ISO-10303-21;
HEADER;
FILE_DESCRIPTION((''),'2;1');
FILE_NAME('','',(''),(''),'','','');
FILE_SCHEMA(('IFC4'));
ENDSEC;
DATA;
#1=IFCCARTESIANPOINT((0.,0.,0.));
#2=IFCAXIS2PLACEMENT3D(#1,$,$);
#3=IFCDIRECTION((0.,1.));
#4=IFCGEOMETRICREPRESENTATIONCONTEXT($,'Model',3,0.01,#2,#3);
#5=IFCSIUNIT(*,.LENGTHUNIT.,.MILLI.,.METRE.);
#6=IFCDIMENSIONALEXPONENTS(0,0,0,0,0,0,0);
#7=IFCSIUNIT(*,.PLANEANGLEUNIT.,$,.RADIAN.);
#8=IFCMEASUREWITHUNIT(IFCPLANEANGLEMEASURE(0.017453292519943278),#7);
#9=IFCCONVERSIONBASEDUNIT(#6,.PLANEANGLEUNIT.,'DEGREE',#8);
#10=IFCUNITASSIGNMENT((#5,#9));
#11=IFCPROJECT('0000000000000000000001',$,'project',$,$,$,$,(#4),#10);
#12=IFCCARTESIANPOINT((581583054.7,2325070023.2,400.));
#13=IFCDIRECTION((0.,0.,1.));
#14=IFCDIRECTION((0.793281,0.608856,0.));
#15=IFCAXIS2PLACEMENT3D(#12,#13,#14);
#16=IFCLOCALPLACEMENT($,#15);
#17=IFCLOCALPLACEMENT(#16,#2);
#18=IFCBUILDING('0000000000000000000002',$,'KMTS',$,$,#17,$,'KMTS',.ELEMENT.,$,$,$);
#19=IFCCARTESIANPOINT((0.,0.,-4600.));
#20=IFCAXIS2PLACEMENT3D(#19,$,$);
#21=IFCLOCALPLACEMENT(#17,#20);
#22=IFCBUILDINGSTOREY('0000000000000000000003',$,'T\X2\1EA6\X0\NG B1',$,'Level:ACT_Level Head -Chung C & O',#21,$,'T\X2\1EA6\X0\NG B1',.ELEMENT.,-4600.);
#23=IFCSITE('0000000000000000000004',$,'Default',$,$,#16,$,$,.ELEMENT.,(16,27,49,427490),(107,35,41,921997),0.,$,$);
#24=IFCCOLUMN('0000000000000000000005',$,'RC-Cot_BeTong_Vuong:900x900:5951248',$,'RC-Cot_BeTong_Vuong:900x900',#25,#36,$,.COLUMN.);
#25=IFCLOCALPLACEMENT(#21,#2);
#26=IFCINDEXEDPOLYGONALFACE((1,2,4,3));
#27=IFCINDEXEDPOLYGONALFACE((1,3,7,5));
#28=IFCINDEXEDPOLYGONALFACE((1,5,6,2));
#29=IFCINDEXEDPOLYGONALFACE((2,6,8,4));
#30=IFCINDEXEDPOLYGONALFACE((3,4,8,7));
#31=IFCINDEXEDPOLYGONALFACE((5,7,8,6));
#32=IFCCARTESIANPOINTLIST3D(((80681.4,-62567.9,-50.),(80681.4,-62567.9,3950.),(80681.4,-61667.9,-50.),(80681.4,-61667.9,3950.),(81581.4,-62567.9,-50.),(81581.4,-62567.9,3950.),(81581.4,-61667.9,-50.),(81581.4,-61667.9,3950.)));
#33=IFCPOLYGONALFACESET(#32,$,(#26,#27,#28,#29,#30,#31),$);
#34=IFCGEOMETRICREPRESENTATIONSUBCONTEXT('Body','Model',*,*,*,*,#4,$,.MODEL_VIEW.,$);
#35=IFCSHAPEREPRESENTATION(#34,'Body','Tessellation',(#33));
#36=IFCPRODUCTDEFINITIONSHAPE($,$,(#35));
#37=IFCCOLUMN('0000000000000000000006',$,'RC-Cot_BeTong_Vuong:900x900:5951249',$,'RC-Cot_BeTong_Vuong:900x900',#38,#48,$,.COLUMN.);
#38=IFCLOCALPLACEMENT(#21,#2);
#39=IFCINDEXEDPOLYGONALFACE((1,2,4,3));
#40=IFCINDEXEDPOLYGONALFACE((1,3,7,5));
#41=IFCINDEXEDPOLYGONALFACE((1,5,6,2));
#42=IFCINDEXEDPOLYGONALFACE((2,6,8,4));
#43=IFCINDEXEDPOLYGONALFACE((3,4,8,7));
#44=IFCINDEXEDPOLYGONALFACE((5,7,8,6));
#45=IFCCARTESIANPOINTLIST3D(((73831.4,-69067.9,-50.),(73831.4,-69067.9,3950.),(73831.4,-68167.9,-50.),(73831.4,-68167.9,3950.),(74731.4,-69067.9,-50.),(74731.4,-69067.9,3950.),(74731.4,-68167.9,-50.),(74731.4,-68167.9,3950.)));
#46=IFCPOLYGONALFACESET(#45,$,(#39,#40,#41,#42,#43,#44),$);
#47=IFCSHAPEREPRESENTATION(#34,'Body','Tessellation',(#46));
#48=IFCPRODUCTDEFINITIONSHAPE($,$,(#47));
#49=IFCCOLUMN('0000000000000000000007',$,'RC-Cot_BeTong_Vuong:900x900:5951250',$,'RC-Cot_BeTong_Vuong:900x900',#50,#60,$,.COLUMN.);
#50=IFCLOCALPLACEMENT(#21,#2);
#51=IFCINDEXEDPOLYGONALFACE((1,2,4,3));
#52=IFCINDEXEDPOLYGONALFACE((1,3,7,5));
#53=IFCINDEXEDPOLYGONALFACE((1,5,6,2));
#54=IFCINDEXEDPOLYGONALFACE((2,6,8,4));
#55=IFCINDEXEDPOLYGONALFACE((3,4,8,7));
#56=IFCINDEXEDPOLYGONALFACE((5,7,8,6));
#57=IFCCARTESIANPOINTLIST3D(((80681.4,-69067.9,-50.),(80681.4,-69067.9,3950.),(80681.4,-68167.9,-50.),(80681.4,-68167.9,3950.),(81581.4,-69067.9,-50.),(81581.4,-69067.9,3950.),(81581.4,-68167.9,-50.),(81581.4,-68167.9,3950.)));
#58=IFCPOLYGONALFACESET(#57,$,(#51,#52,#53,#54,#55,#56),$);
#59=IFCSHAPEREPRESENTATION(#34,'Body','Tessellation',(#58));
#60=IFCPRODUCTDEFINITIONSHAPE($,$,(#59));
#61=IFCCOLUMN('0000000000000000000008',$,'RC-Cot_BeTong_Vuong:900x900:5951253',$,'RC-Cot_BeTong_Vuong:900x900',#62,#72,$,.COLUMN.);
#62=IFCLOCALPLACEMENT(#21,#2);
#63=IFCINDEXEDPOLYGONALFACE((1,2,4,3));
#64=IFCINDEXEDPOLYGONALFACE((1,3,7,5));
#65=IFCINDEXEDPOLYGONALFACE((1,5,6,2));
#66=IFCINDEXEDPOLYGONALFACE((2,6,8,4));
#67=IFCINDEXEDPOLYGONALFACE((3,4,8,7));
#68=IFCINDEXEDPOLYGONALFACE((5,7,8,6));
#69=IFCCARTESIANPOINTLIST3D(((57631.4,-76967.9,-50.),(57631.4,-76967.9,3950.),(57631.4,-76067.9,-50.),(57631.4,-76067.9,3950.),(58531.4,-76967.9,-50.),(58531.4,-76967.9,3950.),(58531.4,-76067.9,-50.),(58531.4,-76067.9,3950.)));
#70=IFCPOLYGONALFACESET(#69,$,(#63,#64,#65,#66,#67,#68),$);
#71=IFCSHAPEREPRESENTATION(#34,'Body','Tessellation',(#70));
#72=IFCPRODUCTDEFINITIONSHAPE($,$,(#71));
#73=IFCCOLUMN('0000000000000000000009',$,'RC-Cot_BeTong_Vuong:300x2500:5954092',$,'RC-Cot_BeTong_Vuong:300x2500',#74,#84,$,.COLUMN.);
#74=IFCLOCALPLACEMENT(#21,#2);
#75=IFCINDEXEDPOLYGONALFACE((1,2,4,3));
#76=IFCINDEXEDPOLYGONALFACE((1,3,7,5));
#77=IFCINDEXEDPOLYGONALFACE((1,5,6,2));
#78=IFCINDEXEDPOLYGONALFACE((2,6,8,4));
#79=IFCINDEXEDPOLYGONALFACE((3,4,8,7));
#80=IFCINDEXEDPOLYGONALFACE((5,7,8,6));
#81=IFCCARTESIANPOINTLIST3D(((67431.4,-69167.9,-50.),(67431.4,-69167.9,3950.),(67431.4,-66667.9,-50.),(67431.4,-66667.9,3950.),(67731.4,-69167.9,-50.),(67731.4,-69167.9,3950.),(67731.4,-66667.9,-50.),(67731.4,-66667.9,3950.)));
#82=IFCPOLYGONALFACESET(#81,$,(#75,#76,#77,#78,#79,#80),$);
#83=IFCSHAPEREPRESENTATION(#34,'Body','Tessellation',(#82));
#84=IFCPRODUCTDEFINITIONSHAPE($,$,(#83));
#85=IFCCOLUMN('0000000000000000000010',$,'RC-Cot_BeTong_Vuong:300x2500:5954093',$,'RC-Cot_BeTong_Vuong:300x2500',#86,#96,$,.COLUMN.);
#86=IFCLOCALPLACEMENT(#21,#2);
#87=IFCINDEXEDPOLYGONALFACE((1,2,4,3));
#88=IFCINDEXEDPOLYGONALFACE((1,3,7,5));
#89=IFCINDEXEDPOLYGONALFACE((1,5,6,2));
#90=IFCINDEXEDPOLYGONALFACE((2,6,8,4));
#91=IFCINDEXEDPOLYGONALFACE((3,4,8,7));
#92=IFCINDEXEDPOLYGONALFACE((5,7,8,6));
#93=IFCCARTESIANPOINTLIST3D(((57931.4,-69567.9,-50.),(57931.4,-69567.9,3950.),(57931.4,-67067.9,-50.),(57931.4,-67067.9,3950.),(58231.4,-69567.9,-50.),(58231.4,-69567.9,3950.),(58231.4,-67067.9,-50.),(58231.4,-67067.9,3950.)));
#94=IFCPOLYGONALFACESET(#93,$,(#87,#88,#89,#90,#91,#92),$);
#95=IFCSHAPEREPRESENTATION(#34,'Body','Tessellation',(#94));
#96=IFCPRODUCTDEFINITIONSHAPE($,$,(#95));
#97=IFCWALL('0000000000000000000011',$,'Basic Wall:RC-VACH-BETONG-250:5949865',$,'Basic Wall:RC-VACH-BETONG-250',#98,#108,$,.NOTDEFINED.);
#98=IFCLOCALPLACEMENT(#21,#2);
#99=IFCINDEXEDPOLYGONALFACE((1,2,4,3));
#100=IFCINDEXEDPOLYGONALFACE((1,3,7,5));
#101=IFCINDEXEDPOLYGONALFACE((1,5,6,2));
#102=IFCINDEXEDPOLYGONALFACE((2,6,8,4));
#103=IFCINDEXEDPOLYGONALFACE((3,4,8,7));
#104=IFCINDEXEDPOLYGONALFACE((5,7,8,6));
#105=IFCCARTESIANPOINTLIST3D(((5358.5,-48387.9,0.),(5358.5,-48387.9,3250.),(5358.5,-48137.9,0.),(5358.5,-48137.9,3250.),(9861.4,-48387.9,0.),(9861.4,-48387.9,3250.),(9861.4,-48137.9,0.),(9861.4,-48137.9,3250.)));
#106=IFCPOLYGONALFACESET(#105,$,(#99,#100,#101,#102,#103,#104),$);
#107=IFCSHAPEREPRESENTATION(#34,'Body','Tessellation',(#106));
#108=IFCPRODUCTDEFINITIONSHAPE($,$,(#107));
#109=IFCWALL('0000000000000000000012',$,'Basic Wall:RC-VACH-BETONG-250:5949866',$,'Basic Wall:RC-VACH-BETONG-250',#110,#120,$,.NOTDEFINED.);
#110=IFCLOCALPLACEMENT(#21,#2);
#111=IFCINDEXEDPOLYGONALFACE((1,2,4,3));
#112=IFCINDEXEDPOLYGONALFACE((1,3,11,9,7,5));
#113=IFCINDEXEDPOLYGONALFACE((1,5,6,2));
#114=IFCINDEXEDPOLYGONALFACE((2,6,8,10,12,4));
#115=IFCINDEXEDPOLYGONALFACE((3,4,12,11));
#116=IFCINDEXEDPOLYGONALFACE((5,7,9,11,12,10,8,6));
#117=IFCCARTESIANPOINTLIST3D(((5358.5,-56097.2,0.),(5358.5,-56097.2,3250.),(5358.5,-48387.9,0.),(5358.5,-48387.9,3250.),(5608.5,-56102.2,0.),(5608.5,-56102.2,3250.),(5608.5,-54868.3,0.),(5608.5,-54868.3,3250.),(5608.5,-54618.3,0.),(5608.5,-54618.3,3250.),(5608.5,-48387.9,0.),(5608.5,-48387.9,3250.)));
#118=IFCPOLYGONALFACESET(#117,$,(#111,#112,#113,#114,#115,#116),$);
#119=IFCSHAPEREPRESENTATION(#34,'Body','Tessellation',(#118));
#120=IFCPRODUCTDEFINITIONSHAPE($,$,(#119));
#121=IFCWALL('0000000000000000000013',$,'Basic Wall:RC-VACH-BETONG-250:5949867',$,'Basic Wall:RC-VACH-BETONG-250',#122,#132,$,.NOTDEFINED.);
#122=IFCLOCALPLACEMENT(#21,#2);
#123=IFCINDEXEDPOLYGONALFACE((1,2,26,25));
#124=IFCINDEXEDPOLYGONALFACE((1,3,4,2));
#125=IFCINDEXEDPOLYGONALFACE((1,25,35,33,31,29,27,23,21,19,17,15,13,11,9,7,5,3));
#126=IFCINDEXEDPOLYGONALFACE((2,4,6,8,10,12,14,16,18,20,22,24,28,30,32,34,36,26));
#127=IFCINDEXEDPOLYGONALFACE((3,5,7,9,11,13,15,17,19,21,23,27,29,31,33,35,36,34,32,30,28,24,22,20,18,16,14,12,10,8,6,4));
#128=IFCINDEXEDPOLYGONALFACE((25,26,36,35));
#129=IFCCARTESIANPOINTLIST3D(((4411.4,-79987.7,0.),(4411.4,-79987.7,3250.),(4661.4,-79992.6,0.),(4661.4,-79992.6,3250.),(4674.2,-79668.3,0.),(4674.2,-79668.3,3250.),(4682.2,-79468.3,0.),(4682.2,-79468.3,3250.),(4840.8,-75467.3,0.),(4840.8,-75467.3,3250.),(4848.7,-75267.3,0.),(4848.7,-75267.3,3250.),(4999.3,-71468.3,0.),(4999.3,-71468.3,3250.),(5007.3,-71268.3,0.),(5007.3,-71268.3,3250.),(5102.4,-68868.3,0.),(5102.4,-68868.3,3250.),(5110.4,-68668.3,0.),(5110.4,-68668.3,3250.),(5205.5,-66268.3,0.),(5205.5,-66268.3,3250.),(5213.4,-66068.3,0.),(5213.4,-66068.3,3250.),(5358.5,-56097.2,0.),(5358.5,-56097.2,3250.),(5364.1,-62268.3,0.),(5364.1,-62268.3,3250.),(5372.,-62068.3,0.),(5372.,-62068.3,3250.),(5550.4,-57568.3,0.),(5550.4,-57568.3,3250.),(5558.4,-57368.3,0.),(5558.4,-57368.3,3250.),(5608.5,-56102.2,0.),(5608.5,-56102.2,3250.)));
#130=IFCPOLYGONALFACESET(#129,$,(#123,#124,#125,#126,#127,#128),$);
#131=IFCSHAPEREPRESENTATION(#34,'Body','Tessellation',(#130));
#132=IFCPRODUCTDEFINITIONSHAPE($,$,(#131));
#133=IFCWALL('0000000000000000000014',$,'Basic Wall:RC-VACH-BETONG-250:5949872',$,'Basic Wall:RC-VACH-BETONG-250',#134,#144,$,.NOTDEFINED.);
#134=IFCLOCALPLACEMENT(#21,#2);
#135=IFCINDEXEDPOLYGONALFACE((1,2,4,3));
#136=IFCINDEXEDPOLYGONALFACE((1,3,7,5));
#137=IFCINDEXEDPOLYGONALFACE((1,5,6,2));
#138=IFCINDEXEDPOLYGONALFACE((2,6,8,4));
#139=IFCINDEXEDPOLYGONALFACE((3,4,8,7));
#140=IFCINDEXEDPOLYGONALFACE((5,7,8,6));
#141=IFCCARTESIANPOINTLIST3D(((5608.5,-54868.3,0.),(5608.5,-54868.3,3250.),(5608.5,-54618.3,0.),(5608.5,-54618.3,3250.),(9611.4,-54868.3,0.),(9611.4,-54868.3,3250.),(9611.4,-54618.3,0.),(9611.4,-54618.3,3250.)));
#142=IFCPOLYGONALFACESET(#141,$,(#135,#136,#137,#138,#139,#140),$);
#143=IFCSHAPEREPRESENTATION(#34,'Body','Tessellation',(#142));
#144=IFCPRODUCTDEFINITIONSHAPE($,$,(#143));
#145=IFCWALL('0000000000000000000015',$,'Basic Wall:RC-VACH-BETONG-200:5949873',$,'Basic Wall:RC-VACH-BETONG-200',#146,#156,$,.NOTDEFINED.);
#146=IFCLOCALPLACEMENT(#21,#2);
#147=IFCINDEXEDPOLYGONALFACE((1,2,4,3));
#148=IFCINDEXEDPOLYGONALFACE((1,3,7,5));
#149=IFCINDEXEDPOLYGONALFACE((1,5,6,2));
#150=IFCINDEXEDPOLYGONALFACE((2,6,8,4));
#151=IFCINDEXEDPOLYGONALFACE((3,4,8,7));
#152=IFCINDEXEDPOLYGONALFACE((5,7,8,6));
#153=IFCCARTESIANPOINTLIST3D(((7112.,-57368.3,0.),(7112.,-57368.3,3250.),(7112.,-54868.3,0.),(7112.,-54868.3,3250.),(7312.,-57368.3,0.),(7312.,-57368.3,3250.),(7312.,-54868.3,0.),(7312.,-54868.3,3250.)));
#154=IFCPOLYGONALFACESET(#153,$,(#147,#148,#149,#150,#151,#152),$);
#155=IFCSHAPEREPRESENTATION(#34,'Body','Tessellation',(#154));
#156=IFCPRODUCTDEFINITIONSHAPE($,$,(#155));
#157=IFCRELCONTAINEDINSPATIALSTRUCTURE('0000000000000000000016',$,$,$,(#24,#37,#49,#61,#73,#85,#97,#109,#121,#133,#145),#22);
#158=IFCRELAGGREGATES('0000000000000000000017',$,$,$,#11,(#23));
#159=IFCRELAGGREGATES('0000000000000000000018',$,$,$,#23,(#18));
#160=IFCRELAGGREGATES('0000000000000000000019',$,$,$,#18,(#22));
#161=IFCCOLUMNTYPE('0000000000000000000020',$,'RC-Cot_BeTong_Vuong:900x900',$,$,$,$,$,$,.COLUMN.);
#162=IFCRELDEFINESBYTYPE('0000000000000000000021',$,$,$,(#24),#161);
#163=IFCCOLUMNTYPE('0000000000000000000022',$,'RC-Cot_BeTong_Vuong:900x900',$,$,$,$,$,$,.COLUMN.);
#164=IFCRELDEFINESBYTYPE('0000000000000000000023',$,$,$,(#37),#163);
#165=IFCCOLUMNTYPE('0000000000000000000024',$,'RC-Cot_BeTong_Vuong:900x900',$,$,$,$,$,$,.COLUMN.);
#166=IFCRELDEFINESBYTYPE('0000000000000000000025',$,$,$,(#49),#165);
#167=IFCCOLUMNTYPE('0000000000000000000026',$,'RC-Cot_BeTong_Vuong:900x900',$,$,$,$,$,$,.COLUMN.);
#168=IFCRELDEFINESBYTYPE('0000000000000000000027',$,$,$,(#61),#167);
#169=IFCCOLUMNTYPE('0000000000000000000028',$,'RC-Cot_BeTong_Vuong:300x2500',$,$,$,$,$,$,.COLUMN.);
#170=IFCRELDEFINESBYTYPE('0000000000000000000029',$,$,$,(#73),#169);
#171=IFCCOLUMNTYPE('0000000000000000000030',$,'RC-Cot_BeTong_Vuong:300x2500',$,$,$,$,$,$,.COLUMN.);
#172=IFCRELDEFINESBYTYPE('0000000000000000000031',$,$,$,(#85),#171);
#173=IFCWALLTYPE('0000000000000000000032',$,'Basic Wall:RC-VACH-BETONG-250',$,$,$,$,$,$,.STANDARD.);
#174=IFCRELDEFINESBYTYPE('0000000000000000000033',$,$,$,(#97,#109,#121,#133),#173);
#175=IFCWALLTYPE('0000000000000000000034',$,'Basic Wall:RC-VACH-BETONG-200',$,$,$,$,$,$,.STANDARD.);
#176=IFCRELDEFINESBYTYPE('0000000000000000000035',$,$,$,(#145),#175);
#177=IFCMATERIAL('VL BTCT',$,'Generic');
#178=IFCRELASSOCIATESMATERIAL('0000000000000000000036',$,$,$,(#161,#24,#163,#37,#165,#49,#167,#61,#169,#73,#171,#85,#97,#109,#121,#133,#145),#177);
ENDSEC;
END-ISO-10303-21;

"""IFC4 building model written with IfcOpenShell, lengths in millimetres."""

from ifc_helpers import new_model, entity, si_unit, converted_unit, direction, frame, origin, place, context, subcontext, project, spatial, indexed_curve, outline, extrude, source, transform, mapped, material, type_object, type_shapes, element, save


model = new_model("IFC4")

# Units and contexts
model_context = context("Model", 3, precision=0.01, world=origin(), true_north=direction((0.0, 1.0)))
body_context = subcontext(model_context, "Body", "Model", "MODEL_VIEW")
ifc_project = project(units=[si_unit("LENGTHUNIT", "METRE", prefix="MILLI"), converted_unit("PLANEANGLEUNIT", "DEGREE", entity("IfcPlaneAngleMeasure", 0.017453292519943278), si_unit("PLANEANGLEUNIT", "RADIAN"), dimensions=[0, 0, 0, 0, 0, 0, 0])], contexts=[model_context])

# Site, building, storey
site_placement = place(None, frame((581583054.7, 2325070023.2, 400.0), z_axis=(0.0, 0.0, 1.0), x_axis=(0.793281, 0.608856, 0.0)))
site = spatial("IfcSite", under=ifc_project, at=site_placement, Name="Default", CompositionType="ELEMENT", RefLatitude=(16, 27, 49, 427490), RefLongitude=(107, 35, 41, 921997), RefElevation=0.0)
building_placement = place(site_placement, origin())
building = spatial("IfcBuilding", under=site, at=building_placement, Name="KMTS", LongName="KMTS", CompositionType="ELEMENT")
storey_placement = place(building_placement, frame((0.0, 0.0, -4600.0)))
storey = spatial("IfcBuildingStorey", under=building, at=storey_placement, Name="TẦNG B1", ObjectType="Level:ACT_Level Head -Chung C & O", LongName="TẦNG B1", CompositionType="ELEMENT", Elevation=-4600.0)

# Columns
ifc_material = material(Name="VL BTCT", Category="Generic")
column_type_1 = type_object("IfcColumnType", Name="RC-Cot_BeTong_Vuong:900x900", PredefinedType="COLUMN", material=ifc_material)
shared_shape_1 = source(origin(), body_context, "Body", "SweptSolid", [
    extrude(outline(indexed_curve([(-450.0, -450.0), (450.0, -450.0), (450.0, 450.0), (-450.0, 450.0), (-450.0, -450.0)], self_intersect=False)), frame((81131.4, -62117.9, -4650.0), z_axis=(0.0, 0.0, 1.0), x_axis=(-1.0, 0.0, 0.0)), (0.0, 0.0, 1.0), 4000.0),
])
type_shapes(column_type_1, [shared_shape_1])
column_1_placement = place(storey_placement, frame((0.0, 0.0, 4600.0)))
element("IfcColumn", 1, at=column_1_placement, inside=storey, type_object=column_type_1, material=ifc_material, Name="RC-Cot_BeTong_Vuong:900x900:5951248", ObjectType="RC-Cot_BeTong_Vuong:900x900", PredefinedType="COLUMN", context=body_context, shape_type="MappedRepresentation", body=[
    mapped(shared_shape_1, transform((0.0, 0.0, 0.0), scale=1.0)),
])
column_type_2 = type_object("IfcColumnType", Name="RC-Cot_BeTong_Vuong:900x900", PredefinedType="COLUMN", material=ifc_material)
shared_shape_2 = source(origin(), body_context, "Body", "SweptSolid", [
    extrude(outline(indexed_curve([(-450.0, -450.0), (450.0, -450.0), (450.0, 450.0), (-450.0, 450.0), (-450.0, -450.0)], self_intersect=False)), frame((74281.4, -68617.9, -4650.0), z_axis=(0.0, 0.0, 1.0), x_axis=(-1.0, 0.0, 0.0)), (0.0, 0.0, 1.0), 4000.0),
])
type_shapes(column_type_2, [shared_shape_2])
column_2_placement = place(storey_placement, frame((0.0, 0.0, 4600.0)))
element("IfcColumn", 2, at=column_2_placement, inside=storey, type_object=column_type_2, material=ifc_material, Name="RC-Cot_BeTong_Vuong:900x900:5951249", ObjectType="RC-Cot_BeTong_Vuong:900x900", PredefinedType="COLUMN", context=body_context, shape_type="MappedRepresentation", body=[
    mapped(shared_shape_2, transform((0.0, 0.0, 0.0), scale=1.0)),
])
column_type_3 = type_object("IfcColumnType", Name="RC-Cot_BeTong_Vuong:900x900", PredefinedType="COLUMN", material=ifc_material)
shared_shape_3 = source(origin(), body_context, "Body", "SweptSolid", [
    extrude(outline(indexed_curve([(-450.0, -450.0), (450.0, -450.0), (450.0, 450.0), (-450.0, 450.0), (-450.0, -450.0)], self_intersect=False)), frame((81131.4, -68617.9, -4650.0), z_axis=(0.0, 0.0, 1.0), x_axis=(-1.0, 0.0, 0.0)), (0.0, 0.0, 1.0), 4000.0),
])
type_shapes(column_type_3, [shared_shape_3])
column_3_placement = place(storey_placement, frame((0.0, 0.0, 4600.0)))
element("IfcColumn", 3, at=column_3_placement, inside=storey, type_object=column_type_3, material=ifc_material, Name="RC-Cot_BeTong_Vuong:900x900:5951250", ObjectType="RC-Cot_BeTong_Vuong:900x900", PredefinedType="COLUMN", context=body_context, shape_type="MappedRepresentation", body=[
    mapped(shared_shape_3, transform((0.0, 0.0, 0.0), scale=1.0)),
])
column_type_4 = type_object("IfcColumnType", Name="RC-Cot_BeTong_Vuong:900x900", PredefinedType="COLUMN", material=ifc_material)
shared_shape_4 = source(origin(), body_context, "Body", "SweptSolid", [
    extrude(outline(indexed_curve([(-450.0, -450.0), (450.0, -450.0), (450.0, 450.0), (-450.0, 450.0), (-450.0, -450.0)], self_intersect=False)), frame((58081.4, -76517.9, -4650.0), z_axis=(0.0, 0.0, 1.0), x_axis=(-1.0, 0.0, 0.0)), (0.0, 0.0, 1.0), 4000.0),
])
type_shapes(column_type_4, [shared_shape_4])
column_4_placement = place(storey_placement, frame((0.0, 0.0, 4600.0)))
element("IfcColumn", 4, at=column_4_placement, inside=storey, type_object=column_type_4, material=ifc_material, Name="RC-Cot_BeTong_Vuong:900x900:5951253", ObjectType="RC-Cot_BeTong_Vuong:900x900", PredefinedType="COLUMN", context=body_context, shape_type="MappedRepresentation", body=[
    mapped(shared_shape_4, transform((0.0, 0.0, 0.0), scale=1.0)),
])
column_type_5 = type_object("IfcColumnType", Name="RC-Cot_BeTong_Vuong:300x2500", PredefinedType="COLUMN", material=ifc_material)
shared_shape_5 = source(origin(), body_context, "Body", "SweptSolid", [
    extrude(outline(indexed_curve([(-2000.0, -1250.0), (2000.0, -1250.0), (2000.0, 1250.0), (-2000.0, 1250.0), (-2000.0, -1250.0)], self_intersect=False)), frame((67431.4, -67917.9, -2650.0), z_axis=(1.0, 0.0, 0.0), x_axis=(0.0, 0.0, 1.0)), (0.0, 0.0, 1.0), 300.0),
])
type_shapes(column_type_5, [shared_shape_5])
column_5_placement = place(storey_placement, frame((0.0, 0.0, 4600.0)))
element("IfcColumn", 5, at=column_5_placement, inside=storey, type_object=column_type_5, material=ifc_material, Name="RC-Cot_BeTong_Vuong:300x2500:5954092", ObjectType="RC-Cot_BeTong_Vuong:300x2500", PredefinedType="COLUMN", context=body_context, shape_type="MappedRepresentation", body=[
    mapped(shared_shape_5, transform((0.0, 0.0, 0.0), scale=1.0)),
])
column_type_6 = type_object("IfcColumnType", Name="RC-Cot_BeTong_Vuong:300x2500", PredefinedType="COLUMN", material=ifc_material)
shared_shape_6 = source(origin(), body_context, "Body", "SweptSolid", [
    extrude(outline(indexed_curve([(-2000.0, -1250.0), (2000.0, -1250.0), (2000.0, 1250.0), (-2000.0, 1250.0), (-2000.0, -1250.0)], self_intersect=False)), frame((57931.4, -68317.9, -2650.0), z_axis=(1.0, 0.0, 0.0), x_axis=(0.0, 0.0, 1.0)), (0.0, 0.0, 1.0), 300.0),
])
type_shapes(column_type_6, [shared_shape_6])
column_6_placement = place(storey_placement, frame((0.0, 0.0, 4600.0)))
element("IfcColumn", 6, at=column_6_placement, inside=storey, type_object=column_type_6, material=ifc_material, Name="RC-Cot_BeTong_Vuong:300x2500:5954093", ObjectType="RC-Cot_BeTong_Vuong:300x2500", PredefinedType="COLUMN", context=body_context, shape_type="MappedRepresentation", body=[
    mapped(shared_shape_6, transform((0.0, 0.0, 0.0), scale=1.0)),
])

# Walls
wall_type_1 = type_object("IfcWallType", Name="Basic Wall:RC-VACH-BETONG-250", PredefinedType="STANDARD")
wall_1_placement = place(storey_placement, frame((9861.4, -48262.9, 0.0), z_axis=(0.0, 0.0, 1.0), x_axis=(-1.0, 0.0, 0.0)))
element("IfcWall", 7, at=wall_1_placement, inside=storey, type_object=wall_type_1, material=ifc_material, Name="Basic Wall:RC-VACH-BETONG-250:5949865", ObjectType="Basic Wall:RC-VACH-BETONG-250", PredefinedType="NOTDEFINED", context=body_context, shape_type="SweptSolid", body=[
    extrude(outline(indexed_curve([(4502.8, 125.0), (0.0, 125.0), (0.0, -125.0), (4502.8, -125.0), (4502.8, 125.0)], self_intersect=False)), origin(), (0.0, 0.0, 1.0), 3250.0),
])
wall_2_placement = place(storey_placement, frame((5483.5, -48387.9, 0.0), z_axis=(0.0, 0.0, 1.0), x_axis=(0.0, -1.0, 0.0)))
element("IfcWall", 8, at=wall_2_placement, inside=storey, type_object=wall_type_1, material=ifc_material, Name="Basic Wall:RC-VACH-BETONG-250:5949866", ObjectType="Basic Wall:RC-VACH-BETONG-250", PredefinedType="NOTDEFINED", context=body_context, shape_type="SweptSolid", body=[
    extrude(outline(indexed_curve([(7709.3, -125.0), (7714.2, 125.0), (6480.3, 125.0), (6230.3, 125.0), (0.0, 125.0), (0.0, -125.0), (7709.3, -125.0)], self_intersect=False)), origin(), (0.0, 0.0, 1.0), 3250.0),
])
wall_3_placement = place(storey_placement, frame((5483.6, -56097.2, 0.0), z_axis=(0.0, 0.0, 1.0), x_axis=(-0.039615, -0.999215, 0.0)))
element("IfcWall", 9, at=wall_3_placement, inside=storey, type_object=wall_type_1, material=ifc_material, Name="Basic Wall:RC-VACH-BETONG-250:5949867", ObjectType="Basic Wall:RC-VACH-BETONG-250", PredefinedType="NOTDEFINED", context=body_context, shape_type="SweptSolid", body=[
    extrude(outline(indexed_curve([(23914.2, -125.0), (23909.2, 125.0), (23584.6, 125.0), (23384.4, 125.0), (19380.4, 125.0), (19180.2, 125.0), (15378.2, 125.0), (15178.0, 125.0), (12776.1, 125.0), (12576.0, 125.0), (10174.1, 125.0), (9973.9, 125.0), (6170.9, 125.0), (5970.8, 125.0), (1467.2, 125.0), (1267.1, 125.0), (0.0, 125.0), (5.0, -125.0), (23914.2, -125.0)], self_intersect=False)), origin(), (0.0, 0.0, 1.0), 3250.0),
])
wall_4_placement = place(storey_placement, frame((9611.4, -54743.3, 0.0), z_axis=(0.0, 0.0, 1.0), x_axis=(-1.0, 0.0, 0.0)))
element("IfcWall", 10, at=wall_4_placement, inside=storey, type_object=wall_type_1, material=ifc_material, Name="Basic Wall:RC-VACH-BETONG-250:5949872", ObjectType="Basic Wall:RC-VACH-BETONG-250", PredefinedType="NOTDEFINED", context=body_context, shape_type="SweptSolid", body=[
    extrude(outline(indexed_curve([(4002.8, 125.0), (0.0, 125.0), (0.0, -125.0), (4002.8, -125.0), (4002.8, 125.0)], self_intersect=False)), origin(), (0.0, 0.0, 1.0), 3250.0),
])
wall_type_2 = type_object("IfcWallType", Name="Basic Wall:RC-VACH-BETONG-200", PredefinedType="STANDARD")
wall_5_placement = place(storey_placement, frame((7212.0, -54868.3, 0.0), z_axis=(0.0, 0.0, 1.0), x_axis=(0.0, -1.0, 0.0)))
element("IfcWall", 11, at=wall_5_placement, inside=storey, type_object=wall_type_2, material=ifc_material, Name="Basic Wall:RC-VACH-BETONG-200:5949873", ObjectType="Basic Wall:RC-VACH-BETONG-200", PredefinedType="NOTDEFINED", context=body_context, shape_type="SweptSolid", body=[
    extrude(outline(indexed_curve([(2500.0, 100.0), (0.0, 100.0), (0.0, -100.0), (2500.0, -100.0), (2500.0, 100.0)], self_intersect=False)), origin(), (0.0, 0.0, 1.0), 3250.0),
])

save(model, "model.ifc")
